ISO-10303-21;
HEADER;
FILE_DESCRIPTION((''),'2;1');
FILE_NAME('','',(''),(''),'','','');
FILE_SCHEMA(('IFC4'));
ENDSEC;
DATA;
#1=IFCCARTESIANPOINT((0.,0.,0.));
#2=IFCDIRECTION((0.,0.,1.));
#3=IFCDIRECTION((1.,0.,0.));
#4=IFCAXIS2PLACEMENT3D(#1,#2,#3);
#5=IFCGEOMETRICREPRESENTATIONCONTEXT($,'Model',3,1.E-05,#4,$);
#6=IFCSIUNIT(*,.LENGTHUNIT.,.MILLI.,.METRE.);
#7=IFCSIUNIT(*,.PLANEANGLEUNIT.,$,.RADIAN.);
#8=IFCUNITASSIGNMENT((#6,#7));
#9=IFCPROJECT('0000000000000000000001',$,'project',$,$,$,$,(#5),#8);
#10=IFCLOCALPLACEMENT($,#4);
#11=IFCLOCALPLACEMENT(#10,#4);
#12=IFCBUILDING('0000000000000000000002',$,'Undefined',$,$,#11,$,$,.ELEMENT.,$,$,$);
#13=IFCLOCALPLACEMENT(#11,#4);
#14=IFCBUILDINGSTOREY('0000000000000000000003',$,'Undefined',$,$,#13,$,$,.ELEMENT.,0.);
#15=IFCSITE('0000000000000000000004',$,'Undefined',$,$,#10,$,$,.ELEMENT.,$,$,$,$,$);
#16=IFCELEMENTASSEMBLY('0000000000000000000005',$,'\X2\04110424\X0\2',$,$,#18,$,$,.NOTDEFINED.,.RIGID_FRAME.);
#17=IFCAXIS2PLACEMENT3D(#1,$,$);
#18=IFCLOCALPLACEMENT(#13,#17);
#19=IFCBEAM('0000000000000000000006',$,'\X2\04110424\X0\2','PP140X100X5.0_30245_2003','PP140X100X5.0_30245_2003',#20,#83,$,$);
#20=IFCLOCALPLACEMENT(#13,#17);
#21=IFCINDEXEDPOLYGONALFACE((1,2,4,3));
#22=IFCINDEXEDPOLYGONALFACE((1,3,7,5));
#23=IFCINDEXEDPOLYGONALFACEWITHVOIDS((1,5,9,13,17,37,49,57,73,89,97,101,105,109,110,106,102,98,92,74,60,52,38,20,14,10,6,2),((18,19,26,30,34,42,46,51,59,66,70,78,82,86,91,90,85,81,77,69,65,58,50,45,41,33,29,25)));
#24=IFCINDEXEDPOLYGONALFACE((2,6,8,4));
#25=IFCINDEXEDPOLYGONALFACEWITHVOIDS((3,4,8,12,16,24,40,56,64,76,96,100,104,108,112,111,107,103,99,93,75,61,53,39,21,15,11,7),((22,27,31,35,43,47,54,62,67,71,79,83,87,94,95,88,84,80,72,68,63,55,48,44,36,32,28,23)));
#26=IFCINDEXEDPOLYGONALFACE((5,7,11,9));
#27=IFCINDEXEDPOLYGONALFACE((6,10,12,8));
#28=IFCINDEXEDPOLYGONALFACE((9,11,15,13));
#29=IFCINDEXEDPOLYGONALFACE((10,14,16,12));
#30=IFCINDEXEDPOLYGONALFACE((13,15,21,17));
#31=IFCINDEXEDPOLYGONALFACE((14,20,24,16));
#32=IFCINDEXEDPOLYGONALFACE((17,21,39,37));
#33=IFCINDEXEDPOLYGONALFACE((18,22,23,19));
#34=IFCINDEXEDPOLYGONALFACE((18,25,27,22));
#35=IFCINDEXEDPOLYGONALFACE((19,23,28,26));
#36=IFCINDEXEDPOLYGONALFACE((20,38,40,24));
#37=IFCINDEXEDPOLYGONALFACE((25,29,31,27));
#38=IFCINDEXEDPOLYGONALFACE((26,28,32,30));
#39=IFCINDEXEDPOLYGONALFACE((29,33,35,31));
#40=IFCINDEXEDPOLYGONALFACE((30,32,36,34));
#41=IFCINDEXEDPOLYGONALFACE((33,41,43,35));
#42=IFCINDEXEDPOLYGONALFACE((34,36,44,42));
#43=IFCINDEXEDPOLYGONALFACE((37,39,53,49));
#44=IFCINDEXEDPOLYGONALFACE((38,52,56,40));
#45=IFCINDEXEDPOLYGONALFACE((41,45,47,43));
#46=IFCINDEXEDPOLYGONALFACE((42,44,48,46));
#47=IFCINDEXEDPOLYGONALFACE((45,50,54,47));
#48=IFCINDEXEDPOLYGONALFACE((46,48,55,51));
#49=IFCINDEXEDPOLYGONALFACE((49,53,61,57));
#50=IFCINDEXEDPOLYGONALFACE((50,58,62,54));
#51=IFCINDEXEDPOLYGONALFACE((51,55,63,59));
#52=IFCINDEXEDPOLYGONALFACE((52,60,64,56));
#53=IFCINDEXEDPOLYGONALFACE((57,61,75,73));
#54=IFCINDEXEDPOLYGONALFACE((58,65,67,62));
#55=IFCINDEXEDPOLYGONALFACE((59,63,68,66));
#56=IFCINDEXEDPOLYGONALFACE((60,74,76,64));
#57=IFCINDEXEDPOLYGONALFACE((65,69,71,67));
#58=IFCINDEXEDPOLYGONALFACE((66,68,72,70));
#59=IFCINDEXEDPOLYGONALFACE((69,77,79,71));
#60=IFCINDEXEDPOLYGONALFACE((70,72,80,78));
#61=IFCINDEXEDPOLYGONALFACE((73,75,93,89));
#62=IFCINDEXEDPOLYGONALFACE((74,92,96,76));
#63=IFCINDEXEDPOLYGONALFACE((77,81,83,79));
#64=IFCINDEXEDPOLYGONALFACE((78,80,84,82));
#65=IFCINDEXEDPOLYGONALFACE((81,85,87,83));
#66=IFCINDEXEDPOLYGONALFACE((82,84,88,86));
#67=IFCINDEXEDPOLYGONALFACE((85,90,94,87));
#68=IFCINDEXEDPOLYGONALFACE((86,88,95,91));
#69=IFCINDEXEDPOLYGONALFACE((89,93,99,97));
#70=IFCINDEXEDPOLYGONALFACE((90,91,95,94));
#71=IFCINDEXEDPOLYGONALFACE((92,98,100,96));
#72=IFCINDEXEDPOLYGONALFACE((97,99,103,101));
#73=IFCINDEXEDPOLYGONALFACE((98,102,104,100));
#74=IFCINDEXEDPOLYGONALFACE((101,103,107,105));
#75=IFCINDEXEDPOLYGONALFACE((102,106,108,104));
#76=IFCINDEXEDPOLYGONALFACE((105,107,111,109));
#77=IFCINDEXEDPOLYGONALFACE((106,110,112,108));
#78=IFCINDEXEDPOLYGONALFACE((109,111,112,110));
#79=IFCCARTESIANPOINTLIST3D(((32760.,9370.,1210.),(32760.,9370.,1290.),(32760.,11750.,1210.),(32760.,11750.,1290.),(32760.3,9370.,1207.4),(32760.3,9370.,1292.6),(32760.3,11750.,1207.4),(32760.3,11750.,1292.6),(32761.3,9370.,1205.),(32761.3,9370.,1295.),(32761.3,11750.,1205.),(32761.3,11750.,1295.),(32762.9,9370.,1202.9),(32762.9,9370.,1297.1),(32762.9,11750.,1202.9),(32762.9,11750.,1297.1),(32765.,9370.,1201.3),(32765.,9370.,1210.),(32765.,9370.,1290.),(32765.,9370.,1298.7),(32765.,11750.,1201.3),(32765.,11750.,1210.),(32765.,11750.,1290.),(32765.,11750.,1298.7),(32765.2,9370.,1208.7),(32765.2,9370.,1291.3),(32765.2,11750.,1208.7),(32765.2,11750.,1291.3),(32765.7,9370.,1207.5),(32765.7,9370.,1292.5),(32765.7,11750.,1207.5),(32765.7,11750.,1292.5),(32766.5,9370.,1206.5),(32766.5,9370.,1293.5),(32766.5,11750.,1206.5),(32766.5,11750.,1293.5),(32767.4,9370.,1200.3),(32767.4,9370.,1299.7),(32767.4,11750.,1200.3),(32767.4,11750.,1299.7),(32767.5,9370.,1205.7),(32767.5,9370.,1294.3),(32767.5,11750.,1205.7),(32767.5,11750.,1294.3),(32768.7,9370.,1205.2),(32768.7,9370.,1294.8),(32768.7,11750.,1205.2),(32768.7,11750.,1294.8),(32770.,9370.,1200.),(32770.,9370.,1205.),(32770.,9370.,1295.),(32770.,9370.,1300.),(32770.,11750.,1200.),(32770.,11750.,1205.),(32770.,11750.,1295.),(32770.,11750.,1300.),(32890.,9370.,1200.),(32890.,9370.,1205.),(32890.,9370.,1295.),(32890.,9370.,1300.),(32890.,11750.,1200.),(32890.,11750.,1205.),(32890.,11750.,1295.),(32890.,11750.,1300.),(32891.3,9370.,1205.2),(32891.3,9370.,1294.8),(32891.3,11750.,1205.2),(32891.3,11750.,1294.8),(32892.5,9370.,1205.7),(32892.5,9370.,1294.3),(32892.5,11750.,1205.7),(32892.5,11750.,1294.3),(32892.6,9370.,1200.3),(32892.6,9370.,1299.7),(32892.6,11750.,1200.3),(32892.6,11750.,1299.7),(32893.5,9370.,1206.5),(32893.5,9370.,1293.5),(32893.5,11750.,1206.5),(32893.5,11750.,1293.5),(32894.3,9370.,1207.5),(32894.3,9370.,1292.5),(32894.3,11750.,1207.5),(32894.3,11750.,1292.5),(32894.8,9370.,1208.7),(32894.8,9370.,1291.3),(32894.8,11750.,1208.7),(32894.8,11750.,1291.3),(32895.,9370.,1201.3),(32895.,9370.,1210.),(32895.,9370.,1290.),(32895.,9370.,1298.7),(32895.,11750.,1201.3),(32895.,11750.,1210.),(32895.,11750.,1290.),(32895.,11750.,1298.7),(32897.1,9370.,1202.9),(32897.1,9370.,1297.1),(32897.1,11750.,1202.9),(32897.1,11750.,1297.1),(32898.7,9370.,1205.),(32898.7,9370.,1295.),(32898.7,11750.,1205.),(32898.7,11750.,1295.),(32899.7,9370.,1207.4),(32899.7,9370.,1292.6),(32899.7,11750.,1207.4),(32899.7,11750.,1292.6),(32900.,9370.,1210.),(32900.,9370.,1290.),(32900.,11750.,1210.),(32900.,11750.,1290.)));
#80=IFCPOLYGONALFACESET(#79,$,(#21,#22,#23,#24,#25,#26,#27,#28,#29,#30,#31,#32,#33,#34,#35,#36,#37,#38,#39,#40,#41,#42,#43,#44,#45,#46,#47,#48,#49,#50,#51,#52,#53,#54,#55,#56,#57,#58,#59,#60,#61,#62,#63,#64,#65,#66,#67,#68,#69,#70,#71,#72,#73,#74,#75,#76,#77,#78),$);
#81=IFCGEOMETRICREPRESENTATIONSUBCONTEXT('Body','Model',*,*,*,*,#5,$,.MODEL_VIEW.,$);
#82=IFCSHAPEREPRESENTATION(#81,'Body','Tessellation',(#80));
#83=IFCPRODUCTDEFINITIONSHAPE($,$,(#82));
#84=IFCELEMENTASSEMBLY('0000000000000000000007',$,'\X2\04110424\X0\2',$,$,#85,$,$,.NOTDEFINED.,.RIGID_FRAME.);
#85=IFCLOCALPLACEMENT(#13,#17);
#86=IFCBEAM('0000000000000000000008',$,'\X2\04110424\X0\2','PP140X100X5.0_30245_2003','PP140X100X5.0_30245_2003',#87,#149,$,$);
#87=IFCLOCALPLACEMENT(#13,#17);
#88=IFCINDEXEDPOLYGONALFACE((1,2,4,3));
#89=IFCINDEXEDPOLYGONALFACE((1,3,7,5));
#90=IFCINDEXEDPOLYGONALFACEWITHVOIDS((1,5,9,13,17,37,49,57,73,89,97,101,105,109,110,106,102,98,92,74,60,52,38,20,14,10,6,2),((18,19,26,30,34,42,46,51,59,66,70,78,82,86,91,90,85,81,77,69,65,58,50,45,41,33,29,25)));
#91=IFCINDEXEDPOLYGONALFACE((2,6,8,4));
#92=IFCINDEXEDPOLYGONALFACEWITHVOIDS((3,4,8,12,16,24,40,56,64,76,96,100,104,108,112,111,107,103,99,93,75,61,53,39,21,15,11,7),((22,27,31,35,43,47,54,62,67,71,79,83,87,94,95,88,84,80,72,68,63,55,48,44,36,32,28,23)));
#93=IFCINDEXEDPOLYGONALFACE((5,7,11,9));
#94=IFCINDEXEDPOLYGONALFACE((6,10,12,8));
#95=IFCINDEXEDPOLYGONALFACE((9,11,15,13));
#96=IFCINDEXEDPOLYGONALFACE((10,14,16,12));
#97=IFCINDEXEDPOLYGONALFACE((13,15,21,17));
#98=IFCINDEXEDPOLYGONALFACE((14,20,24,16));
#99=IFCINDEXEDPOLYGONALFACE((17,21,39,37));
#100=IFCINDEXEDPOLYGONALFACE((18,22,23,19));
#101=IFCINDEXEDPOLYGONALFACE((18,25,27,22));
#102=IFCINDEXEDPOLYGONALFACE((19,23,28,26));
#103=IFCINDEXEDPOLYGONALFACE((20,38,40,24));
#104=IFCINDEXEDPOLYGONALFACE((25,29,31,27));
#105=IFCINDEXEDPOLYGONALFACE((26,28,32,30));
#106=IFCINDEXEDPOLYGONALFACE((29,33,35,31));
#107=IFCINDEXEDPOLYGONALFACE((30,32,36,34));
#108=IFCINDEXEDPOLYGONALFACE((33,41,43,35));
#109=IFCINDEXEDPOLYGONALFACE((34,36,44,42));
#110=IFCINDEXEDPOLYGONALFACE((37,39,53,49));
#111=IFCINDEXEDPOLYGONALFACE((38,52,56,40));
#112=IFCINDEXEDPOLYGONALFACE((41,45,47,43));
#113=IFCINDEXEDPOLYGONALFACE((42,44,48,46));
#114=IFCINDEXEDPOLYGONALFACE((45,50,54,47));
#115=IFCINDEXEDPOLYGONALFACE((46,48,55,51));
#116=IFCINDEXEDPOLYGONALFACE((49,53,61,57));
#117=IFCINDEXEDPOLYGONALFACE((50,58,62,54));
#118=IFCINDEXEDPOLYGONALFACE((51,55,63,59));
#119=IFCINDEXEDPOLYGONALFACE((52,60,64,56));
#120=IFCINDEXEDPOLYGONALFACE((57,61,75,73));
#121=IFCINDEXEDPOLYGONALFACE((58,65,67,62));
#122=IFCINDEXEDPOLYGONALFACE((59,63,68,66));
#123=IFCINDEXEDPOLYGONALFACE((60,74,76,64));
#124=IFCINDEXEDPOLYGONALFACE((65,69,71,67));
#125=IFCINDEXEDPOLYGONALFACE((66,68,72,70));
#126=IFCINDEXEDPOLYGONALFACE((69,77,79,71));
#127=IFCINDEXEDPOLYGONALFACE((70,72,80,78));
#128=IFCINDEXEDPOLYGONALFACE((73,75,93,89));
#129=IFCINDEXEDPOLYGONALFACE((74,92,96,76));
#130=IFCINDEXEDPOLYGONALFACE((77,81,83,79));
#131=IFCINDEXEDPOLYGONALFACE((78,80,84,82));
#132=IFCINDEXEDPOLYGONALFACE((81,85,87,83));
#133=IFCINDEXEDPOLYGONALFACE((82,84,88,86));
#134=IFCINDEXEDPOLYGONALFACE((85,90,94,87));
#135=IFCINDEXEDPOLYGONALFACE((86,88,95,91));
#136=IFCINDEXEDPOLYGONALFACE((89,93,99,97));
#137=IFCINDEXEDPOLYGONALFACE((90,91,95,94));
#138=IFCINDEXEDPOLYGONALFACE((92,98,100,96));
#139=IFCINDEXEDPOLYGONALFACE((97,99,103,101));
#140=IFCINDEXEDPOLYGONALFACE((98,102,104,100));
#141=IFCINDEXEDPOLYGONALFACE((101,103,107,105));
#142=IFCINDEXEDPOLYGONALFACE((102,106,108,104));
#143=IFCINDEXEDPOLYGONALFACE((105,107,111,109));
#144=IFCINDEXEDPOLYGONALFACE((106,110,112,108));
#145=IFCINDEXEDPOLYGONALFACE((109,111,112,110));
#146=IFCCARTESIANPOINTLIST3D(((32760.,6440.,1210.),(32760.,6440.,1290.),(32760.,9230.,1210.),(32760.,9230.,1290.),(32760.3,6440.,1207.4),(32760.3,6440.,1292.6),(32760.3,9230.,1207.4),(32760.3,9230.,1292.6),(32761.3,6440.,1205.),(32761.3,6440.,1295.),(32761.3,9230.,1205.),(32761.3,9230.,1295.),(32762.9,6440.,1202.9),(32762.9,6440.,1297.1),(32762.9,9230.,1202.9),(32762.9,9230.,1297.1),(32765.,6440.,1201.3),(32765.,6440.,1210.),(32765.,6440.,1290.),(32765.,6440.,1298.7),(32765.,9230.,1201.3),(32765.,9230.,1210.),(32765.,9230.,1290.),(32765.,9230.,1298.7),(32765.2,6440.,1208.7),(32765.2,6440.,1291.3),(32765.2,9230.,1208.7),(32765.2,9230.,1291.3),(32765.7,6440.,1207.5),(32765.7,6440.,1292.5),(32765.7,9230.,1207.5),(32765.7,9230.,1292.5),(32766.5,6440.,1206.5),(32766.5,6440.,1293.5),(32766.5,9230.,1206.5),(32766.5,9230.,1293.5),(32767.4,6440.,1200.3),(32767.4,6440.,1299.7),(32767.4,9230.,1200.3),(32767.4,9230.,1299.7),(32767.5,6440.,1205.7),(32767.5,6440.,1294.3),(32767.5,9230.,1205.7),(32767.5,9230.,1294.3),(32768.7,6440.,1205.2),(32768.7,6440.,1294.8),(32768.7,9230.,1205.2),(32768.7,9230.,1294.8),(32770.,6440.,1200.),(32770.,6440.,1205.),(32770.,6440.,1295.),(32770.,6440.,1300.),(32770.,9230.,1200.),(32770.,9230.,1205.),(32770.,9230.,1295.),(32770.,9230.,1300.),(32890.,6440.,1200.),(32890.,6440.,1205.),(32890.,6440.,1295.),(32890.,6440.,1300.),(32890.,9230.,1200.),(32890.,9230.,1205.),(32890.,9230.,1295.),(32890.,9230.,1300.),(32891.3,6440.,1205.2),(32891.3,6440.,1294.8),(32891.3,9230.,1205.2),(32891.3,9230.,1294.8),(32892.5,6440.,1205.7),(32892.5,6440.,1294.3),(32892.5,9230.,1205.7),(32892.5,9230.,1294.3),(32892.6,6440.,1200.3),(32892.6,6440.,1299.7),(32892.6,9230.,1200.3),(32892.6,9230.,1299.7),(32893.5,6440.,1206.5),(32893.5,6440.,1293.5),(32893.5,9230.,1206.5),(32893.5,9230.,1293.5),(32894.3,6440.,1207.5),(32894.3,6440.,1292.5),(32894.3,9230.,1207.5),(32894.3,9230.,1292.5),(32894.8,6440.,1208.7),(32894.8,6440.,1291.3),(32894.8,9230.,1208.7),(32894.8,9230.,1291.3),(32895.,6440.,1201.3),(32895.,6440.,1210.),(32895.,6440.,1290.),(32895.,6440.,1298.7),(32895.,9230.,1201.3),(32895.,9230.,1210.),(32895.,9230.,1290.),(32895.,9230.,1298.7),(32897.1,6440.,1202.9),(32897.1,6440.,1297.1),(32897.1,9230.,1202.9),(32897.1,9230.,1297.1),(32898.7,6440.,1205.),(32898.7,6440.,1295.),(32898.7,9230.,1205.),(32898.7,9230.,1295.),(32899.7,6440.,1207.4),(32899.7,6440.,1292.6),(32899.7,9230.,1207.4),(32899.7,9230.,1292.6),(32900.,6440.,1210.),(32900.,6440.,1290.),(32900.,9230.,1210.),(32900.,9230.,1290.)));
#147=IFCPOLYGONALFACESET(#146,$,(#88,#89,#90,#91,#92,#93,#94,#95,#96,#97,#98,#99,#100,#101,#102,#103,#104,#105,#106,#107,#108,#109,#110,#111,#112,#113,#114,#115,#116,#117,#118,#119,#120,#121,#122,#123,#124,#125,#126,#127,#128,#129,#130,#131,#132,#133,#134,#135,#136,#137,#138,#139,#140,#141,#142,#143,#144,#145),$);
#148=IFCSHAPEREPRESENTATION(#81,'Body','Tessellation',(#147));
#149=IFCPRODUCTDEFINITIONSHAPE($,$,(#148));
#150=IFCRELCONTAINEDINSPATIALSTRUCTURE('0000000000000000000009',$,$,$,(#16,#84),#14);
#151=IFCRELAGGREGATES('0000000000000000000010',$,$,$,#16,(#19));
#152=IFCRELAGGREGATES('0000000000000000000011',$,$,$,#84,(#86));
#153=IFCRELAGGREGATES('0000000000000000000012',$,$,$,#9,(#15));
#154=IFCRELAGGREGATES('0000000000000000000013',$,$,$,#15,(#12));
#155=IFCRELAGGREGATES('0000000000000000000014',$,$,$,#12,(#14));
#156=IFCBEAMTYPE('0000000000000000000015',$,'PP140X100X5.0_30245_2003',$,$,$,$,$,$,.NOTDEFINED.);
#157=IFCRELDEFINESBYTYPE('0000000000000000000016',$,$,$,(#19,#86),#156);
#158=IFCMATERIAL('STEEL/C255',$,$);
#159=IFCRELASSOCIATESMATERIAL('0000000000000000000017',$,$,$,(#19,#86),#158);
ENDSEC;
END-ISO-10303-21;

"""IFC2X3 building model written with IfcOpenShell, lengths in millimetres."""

from ifc_helpers import new_model, si_unit, frame, origin_with_axes, origin_2d_with_axis, place, context, subcontext, project, spatial, hollow_rectangle, extrude, material, type_object, element, aggregate, save


model = new_model("IFC2X3")

# Units and contexts
model_context = context("Model", 3, precision=1e-05, world=origin_with_axes())
body_context = subcontext(model_context, "Body", "Model", "MODEL_VIEW")
ifc_project = project(units=[si_unit("LENGTHUNIT", "METRE", prefix="MILLI"), si_unit("PLANEANGLEUNIT", "RADIAN")], contexts=[model_context])

# Site, building, storey
site_placement = place(None, origin_with_axes())
site = spatial("IfcSite", under=ifc_project, at=site_placement, Name="Undefined", CompositionType="ELEMENT")
building_placement = place(site_placement, origin_with_axes())
building = spatial("IfcBuilding", under=site, at=building_placement, Name="Undefined", CompositionType="ELEMENT")
storey_placement = place(building_placement, origin_with_axes())
storey = spatial("IfcBuildingStorey", under=building, at=storey_placement, Name="Undefined", CompositionType="ELEMENT", Elevation=0.0)

# Shared definitions
ifc_material_1 = material(Name="STEEL/C255")

# Element assemblies, beams
beam_type_1 = type_object("IfcBeamType", Name="PP140X100X5.0_30245_2003", PredefinedType="NOTDEFINED")
assembly_1_placement = place(storey_placement, origin_with_axes())
assembly_1 = element("IfcElementAssembly", 1, at=assembly_1_placement, inside=storey, Name="БФ2", AssemblyPlace="NOTDEFINED", PredefinedType="RIGID_FRAME")
beam_1_placement = place(assembly_1_placement, frame((32830.0, 9370.0, 1250.0), z_axis=(-1.0, 0.0, 0.0), x_axis=(0.0, 1.0, 0.0)))
beam_1 = element("IfcBeam", 2, at=beam_1_placement, type_object=beam_type_1, material=ifc_material_1, Name="БФ2", Description="PP140X100X5.0_30245_2003", ObjectType="PP140X100X5.0_30245_2003", context=body_context, shape_type="SweptSolid", body=[
    extrude(hollow_rectangle(XDim=100.0, YDim=140.0, WallThickness=5.0, InnerFilletRadius=5.0, OuterFilletRadius=10.0, at=origin_2d_with_axis()), frame((2380.0, 0.0, 0.0), z_axis=(-1.0, 0.0, 0.0), x_axis=(0.0, -1.0, 0.0)), (0.0, 0.0, 1.0), 2380.0),
])
aggregate(assembly_1, [beam_1])
assembly_2_placement = place(storey_placement, origin_with_axes())
assembly_2 = element("IfcElementAssembly", 3, at=assembly_2_placement, inside=storey, Name="БФ2", AssemblyPlace="NOTDEFINED", PredefinedType="RIGID_FRAME")
beam_2_placement = place(assembly_2_placement, frame((32830.0, 6440.0, 1250.0), z_axis=(-1.0, 0.0, 0.0), x_axis=(0.0, 1.0, 0.0)))
beam_2 = element("IfcBeam", 4, at=beam_2_placement, type_object=beam_type_1, material=ifc_material_1, Name="БФ2", Description="PP140X100X5.0_30245_2003", ObjectType="PP140X100X5.0_30245_2003", context=body_context, shape_type="SweptSolid", body=[
    extrude(hollow_rectangle(XDim=100.0, YDim=140.0, WallThickness=5.0, InnerFilletRadius=5.0, OuterFilletRadius=10.0, at=origin_2d_with_axis()), frame((2790.0, 0.0, 0.0), z_axis=(-1.0, 0.0, 0.0), x_axis=(0.0, -1.0, 0.0)), (0.0, 0.0, 1.0), 2790.0),
])
aggregate(assembly_2, [beam_2])

save(model, "model.ifc")
